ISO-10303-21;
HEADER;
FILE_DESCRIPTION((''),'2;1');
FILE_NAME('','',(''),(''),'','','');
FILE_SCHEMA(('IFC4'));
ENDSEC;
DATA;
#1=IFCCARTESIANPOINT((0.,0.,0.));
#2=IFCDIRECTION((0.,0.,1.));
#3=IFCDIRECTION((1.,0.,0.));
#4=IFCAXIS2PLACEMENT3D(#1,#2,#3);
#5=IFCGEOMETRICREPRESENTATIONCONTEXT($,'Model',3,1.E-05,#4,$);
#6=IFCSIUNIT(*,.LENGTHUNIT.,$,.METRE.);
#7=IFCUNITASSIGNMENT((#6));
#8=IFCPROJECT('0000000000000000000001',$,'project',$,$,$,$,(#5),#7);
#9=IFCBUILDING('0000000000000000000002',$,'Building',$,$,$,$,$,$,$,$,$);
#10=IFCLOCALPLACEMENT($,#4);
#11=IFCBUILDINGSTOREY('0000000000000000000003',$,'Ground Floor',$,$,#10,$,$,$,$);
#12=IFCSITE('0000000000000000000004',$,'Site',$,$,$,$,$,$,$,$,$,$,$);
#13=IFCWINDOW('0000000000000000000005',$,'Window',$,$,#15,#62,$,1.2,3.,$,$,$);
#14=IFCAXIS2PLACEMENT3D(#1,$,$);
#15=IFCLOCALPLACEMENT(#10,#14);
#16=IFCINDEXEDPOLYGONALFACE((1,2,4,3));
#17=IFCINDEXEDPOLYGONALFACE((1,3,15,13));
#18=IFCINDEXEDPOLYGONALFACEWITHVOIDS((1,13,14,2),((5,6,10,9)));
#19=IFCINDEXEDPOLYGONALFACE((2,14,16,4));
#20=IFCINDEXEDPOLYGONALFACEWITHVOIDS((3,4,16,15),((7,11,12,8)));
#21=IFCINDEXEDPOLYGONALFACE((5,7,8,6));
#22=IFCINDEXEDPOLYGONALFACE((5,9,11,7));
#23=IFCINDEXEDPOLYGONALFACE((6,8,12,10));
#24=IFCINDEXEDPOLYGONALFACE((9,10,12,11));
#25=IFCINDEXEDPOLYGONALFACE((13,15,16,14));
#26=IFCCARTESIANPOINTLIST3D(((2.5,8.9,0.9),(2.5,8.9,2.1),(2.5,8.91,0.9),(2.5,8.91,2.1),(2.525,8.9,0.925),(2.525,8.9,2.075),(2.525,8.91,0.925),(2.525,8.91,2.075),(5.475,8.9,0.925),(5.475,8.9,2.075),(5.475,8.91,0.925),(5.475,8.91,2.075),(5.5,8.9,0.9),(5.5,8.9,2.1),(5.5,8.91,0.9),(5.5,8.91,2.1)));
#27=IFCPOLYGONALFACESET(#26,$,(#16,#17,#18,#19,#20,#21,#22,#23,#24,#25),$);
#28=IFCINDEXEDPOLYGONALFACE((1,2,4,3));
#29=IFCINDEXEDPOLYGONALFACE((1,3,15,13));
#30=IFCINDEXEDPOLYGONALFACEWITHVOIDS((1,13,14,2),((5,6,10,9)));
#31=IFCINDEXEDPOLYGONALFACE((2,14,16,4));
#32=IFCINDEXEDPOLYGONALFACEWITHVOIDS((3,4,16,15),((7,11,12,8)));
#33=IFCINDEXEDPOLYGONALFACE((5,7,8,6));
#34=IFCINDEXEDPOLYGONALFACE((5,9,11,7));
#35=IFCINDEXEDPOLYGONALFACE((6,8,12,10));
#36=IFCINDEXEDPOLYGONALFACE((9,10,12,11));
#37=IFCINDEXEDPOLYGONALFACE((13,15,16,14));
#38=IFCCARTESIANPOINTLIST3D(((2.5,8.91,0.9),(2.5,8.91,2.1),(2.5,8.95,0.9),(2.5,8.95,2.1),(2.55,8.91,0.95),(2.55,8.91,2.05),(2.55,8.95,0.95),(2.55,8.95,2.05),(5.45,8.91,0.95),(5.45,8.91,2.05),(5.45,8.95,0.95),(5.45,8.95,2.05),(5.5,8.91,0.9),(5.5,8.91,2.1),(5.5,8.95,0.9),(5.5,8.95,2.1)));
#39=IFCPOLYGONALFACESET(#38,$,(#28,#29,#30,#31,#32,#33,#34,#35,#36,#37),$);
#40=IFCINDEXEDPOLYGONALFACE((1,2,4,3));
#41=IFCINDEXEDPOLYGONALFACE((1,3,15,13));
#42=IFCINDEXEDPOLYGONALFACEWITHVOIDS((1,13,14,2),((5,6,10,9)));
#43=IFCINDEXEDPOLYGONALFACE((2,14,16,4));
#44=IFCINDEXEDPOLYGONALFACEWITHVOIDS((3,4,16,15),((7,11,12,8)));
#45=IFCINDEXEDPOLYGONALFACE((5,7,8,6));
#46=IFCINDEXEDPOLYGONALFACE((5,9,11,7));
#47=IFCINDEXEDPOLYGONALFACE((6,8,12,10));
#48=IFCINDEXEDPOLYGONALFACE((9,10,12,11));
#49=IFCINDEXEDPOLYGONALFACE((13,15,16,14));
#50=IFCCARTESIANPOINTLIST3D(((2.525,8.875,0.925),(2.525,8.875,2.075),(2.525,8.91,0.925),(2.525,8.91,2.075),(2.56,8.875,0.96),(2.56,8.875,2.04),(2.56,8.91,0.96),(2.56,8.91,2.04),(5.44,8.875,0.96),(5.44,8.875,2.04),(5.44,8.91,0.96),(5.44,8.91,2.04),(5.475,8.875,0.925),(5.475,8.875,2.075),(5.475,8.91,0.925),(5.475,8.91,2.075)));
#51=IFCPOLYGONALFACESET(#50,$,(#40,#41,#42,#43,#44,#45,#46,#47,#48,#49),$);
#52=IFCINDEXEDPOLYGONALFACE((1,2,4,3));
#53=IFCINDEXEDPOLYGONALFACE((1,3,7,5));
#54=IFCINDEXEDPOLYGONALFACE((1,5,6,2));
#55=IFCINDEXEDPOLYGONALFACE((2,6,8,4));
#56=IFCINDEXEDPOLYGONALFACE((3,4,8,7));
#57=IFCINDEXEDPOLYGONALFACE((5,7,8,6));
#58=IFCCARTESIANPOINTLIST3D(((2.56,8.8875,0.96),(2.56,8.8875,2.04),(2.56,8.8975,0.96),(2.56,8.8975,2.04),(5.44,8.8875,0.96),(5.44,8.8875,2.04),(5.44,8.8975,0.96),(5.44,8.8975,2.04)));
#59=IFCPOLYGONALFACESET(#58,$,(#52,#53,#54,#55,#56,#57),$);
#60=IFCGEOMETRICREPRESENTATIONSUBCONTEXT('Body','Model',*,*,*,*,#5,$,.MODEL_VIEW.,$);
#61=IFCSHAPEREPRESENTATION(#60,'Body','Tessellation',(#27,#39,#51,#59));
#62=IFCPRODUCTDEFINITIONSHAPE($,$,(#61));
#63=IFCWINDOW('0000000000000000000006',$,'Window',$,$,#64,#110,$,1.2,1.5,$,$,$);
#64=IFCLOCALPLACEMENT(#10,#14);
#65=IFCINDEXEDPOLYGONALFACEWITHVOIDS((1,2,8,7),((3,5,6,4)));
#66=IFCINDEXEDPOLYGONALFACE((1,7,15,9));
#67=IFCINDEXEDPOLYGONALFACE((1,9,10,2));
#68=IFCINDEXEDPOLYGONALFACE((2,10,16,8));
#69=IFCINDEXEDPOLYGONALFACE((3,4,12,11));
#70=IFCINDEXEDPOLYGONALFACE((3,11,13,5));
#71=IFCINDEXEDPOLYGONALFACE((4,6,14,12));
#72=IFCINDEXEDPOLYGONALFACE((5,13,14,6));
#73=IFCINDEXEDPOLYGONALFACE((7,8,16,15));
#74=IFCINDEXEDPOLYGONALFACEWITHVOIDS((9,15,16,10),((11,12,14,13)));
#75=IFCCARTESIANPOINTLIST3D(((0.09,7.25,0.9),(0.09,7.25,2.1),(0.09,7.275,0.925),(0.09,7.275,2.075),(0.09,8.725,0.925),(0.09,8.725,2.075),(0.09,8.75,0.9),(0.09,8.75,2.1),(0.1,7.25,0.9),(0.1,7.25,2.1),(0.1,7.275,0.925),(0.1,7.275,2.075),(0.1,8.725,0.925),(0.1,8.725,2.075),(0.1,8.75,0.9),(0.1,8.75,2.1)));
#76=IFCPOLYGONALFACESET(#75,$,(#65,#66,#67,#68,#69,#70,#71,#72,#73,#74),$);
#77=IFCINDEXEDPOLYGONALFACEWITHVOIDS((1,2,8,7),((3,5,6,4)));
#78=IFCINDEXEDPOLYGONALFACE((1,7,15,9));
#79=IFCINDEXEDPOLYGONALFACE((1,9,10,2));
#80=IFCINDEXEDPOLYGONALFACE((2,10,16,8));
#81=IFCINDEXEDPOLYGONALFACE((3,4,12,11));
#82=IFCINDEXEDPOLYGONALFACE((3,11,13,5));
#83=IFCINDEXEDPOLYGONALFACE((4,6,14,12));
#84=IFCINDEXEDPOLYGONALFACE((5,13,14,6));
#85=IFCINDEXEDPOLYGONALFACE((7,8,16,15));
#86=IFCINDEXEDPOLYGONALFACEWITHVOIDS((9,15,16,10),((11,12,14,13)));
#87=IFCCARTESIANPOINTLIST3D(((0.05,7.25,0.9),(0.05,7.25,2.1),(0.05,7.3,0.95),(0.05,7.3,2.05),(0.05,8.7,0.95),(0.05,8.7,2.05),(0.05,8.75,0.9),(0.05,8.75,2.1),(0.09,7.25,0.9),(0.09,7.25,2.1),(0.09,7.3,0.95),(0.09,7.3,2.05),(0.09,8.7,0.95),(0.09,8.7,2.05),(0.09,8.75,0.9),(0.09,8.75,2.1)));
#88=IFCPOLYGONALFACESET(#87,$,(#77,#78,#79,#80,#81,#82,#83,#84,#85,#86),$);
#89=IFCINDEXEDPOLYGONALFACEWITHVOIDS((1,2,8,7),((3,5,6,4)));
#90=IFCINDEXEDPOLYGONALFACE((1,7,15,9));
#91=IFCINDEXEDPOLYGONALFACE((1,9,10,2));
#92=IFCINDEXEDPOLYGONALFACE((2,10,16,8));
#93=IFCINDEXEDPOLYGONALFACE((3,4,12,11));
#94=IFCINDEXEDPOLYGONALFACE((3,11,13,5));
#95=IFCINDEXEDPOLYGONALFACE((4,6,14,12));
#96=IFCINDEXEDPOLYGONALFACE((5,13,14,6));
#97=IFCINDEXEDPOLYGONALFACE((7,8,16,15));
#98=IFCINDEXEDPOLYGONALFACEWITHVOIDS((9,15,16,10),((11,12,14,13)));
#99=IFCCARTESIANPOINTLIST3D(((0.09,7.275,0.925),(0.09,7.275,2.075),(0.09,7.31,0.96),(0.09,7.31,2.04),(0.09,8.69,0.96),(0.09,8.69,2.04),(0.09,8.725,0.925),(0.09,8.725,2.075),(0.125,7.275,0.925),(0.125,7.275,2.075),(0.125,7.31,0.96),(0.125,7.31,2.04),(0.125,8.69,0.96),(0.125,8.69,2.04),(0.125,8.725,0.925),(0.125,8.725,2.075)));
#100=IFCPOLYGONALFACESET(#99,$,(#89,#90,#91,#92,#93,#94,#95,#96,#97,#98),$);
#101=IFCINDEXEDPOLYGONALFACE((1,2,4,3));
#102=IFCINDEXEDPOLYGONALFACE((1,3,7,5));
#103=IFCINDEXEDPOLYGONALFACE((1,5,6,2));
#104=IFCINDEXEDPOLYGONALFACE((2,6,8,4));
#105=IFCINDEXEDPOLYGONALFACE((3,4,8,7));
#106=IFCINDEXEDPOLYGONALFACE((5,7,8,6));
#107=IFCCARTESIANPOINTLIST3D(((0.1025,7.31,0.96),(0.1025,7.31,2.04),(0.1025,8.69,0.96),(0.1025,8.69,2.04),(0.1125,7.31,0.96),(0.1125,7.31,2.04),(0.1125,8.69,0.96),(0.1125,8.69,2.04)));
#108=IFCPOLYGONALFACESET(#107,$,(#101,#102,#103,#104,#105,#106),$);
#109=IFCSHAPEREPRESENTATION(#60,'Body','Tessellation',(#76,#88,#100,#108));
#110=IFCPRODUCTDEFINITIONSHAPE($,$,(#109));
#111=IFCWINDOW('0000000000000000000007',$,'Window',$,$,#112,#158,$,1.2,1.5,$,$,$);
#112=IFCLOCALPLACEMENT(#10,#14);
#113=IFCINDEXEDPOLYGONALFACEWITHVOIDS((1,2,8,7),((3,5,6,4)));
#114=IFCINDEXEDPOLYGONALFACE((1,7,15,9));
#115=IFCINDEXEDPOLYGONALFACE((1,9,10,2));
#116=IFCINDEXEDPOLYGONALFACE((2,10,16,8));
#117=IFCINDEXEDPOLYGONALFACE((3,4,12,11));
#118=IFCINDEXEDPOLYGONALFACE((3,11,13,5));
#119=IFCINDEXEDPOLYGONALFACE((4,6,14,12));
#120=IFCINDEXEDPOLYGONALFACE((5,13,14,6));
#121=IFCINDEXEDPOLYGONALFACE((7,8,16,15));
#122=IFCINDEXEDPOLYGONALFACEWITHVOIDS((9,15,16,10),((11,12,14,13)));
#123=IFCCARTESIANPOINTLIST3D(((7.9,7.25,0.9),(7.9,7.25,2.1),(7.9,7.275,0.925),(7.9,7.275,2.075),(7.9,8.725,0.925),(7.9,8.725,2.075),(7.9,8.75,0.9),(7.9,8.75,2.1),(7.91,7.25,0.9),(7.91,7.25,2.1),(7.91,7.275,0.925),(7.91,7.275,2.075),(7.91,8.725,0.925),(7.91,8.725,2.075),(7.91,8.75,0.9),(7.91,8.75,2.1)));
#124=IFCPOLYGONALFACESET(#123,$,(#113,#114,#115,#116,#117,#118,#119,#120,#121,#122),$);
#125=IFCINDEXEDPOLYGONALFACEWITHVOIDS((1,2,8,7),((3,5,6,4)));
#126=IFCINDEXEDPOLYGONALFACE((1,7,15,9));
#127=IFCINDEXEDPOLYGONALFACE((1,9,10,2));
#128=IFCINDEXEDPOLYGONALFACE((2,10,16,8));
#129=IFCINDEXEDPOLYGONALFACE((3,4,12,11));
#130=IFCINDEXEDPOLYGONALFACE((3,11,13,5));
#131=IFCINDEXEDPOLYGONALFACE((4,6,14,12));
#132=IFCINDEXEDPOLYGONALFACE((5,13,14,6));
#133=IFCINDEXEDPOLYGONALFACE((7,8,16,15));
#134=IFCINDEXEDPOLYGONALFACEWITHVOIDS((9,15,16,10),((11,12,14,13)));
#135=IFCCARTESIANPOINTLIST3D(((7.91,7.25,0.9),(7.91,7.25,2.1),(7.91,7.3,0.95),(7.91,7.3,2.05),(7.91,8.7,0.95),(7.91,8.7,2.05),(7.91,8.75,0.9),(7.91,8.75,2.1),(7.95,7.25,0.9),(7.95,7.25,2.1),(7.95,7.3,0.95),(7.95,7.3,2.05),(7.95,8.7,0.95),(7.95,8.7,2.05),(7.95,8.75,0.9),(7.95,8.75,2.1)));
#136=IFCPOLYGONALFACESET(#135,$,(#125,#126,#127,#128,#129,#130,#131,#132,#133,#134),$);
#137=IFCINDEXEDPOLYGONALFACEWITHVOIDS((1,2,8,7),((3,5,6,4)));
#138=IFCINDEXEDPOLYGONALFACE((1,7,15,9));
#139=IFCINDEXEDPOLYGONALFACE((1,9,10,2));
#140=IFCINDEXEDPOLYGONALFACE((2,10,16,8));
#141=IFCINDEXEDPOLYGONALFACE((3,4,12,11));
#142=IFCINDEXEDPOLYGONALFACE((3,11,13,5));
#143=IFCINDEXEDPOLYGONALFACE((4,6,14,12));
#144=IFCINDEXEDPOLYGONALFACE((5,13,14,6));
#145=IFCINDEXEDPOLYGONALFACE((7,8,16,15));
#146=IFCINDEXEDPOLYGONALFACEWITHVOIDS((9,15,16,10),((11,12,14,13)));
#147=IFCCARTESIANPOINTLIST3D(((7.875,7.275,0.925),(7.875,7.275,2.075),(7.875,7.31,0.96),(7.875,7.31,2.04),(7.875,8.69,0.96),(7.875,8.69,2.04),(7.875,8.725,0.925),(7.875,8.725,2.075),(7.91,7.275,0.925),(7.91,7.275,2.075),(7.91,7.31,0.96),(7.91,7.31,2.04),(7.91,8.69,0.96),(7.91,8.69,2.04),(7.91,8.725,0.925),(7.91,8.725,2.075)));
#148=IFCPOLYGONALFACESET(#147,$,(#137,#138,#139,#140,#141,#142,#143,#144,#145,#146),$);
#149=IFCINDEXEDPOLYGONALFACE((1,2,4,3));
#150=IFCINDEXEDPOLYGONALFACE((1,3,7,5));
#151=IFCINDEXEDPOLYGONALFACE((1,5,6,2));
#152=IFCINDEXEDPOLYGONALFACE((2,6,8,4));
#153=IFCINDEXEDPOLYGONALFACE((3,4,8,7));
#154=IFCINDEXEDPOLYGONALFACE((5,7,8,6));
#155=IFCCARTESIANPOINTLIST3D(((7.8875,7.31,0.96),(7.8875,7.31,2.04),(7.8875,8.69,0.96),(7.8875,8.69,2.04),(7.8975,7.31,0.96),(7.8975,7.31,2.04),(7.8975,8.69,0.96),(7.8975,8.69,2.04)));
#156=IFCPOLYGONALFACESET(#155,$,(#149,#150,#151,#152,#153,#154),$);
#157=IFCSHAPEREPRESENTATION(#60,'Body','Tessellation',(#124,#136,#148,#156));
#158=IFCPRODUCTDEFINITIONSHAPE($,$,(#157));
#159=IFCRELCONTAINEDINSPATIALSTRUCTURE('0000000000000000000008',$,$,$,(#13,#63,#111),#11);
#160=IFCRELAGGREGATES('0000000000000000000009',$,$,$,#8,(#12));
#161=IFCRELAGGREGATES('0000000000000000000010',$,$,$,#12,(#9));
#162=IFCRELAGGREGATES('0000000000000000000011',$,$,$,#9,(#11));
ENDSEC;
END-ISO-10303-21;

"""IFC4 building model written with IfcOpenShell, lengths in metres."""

from ifc_helpers import new_model, si_unit, frame, origin_with_axes, place, context, subcontext, project, spatial, line, indexed_curve, outline, extrude, element, save


model = new_model("IFC4")

# Units and contexts
model_context = context("Model", 3, precision=1e-05, world=origin_with_axes())
body_context = subcontext(model_context, "Body", "Model", "MODEL_VIEW")
ifc_project = project(units=[si_unit("LENGTHUNIT", "METRE")], contexts=[model_context])

# Site, building, storey
site = spatial("IfcSite", under=ifc_project, Name="Site")
building = spatial("IfcBuilding", under=site, Name="Building")
storey_placement = place(None, origin_with_axes())
storey = spatial("IfcBuildingStorey", under=building, at=storey_placement, Name="Ground Floor")

# Windows
window_placement = place(storey_placement, frame((5.5, 9.0, 0.9), z_axis=(0.0, 0.0, 1.0), x_axis=(-1.0, 0.0, 0.0)))
element("IfcWindow", 1, at=window_placement, inside=storey, Name="Window", OverallHeight=1.2, OverallWidth=3.0, context=body_context, shape_type="SweptSolid", body=[
    extrude(outline(indexed_curve([(0.0, 0.0), (3.0, 0.0), (3.0, 1.2), (0.0, 1.2)], segments=[line(1, 2, 3, 4, 1)]), holes=[indexed_curve([(0.025, 0.025), (2.975, 0.025), (2.975, 1.175), (0.025, 1.175)], segments=[line(1, 2, 3, 4, 1)])]), frame((0.0, 0.09, 0.0), z_axis=(0.0, -1.0, 0.0), x_axis=(1.0, 0.0, 0.0)), (0.0, 0.0, -1.0), 0.01),
    extrude(outline(indexed_curve([(0.0, 0.0), (3.0, 0.0), (3.0, 1.2), (0.0, 1.2)], segments=[line(1, 2, 3, 4, 1)]), holes=[indexed_curve([(0.05, 0.05), (2.95, 0.05), (2.95, 1.15), (0.05, 1.15)], segments=[line(1, 2, 3, 4, 1)])]), frame((0.0, 0.05, 0.0), z_axis=(0.0, -1.0, 0.0), x_axis=(1.0, 0.0, 0.0)), (0.0, 0.0, -1.0), 0.04),
    extrude(outline(indexed_curve([(0.0, 0.0), (2.95, 0.0), (2.95, 1.15), (0.0, 1.15)], segments=[line(1, 2, 3, 4, 1)]), holes=[indexed_curve([(0.035, 0.035), (2.915, 0.035), (2.915, 1.115), (0.035, 1.115)], segments=[line(1, 2, 3, 4, 1)])]), frame((0.025, 0.09, 0.025), z_axis=(0.0, -1.0, 0.0), x_axis=(1.0, 0.0, 0.0)), (0.0, 0.0, -1.0), 0.035),
    extrude(outline(indexed_curve([(0.035, 0.035), (2.915, 0.035), (2.915, 1.115), (0.035, 1.115)], segments=[line(1, 2, 3, 4, 1)])), frame((0.025, 0.1025, 0.025), z_axis=(0.0, -1.0, 0.0), x_axis=(1.0, 0.0, 0.0)), (0.0, 0.0, -1.0), 0.01),
])
for number, where, z_axis, x_axis, name in (
    (2, (0.0, 8.75, 0.9), (0.0, 0.0, 1.0), (0.0, -1.0, 0.0), "Window"),
    (3, (8.0, 7.25, 0.9), (0.0, 0.0, 1.0), (0.0, 1.0, 0.0), "Window"),
):
    element("IfcWindow", number, at=place(storey_placement, frame(where, z_axis=z_axis, x_axis=x_axis)), inside=storey, Name=name, OverallHeight=1.2, OverallWidth=1.5, context=body_context, shape_type="SweptSolid", body=[
        extrude(outline(indexed_curve([(0.0, 0.0), (1.5, 0.0), (1.5, 1.2), (0.0, 1.2)], segments=[line(1, 2, 3, 4, 1)]), holes=[indexed_curve([(0.025, 0.025), (1.475, 0.025), (1.475, 1.175), (0.025, 1.175)], segments=[line(1, 2, 3, 4, 1)])]), frame((0.0, 0.09, 0.0), z_axis=(0.0, -1.0, 0.0), x_axis=(1.0, 0.0, 0.0)), (0.0, 0.0, -1.0), 0.01),
        extrude(outline(indexed_curve([(0.0, 0.0), (1.5, 0.0), (1.5, 1.2), (0.0, 1.2)], segments=[line(1, 2, 3, 4, 1)]), holes=[indexed_curve([(0.05, 0.05), (1.45, 0.05), (1.45, 1.15), (0.05, 1.15)], segments=[line(1, 2, 3, 4, 1)])]), frame((0.0, 0.05, 0.0), z_axis=(0.0, -1.0, 0.0), x_axis=(1.0, 0.0, 0.0)), (0.0, 0.0, -1.0), 0.04),
        extrude(outline(indexed_curve([(0.0, 0.0), (1.45, 0.0), (1.45, 1.15), (0.0, 1.15)], segments=[line(1, 2, 3, 4, 1)]), holes=[indexed_curve([(0.035, 0.035), (1.415, 0.035), (1.415, 1.115), (0.035, 1.115)], segments=[line(1, 2, 3, 4, 1)])]), frame((0.025, 0.09, 0.025), z_axis=(0.0, -1.0, 0.0), x_axis=(1.0, 0.0, 0.0)), (0.0, 0.0, -1.0), 0.035),
        extrude(outline(indexed_curve([(0.035, 0.035), (1.415, 0.035), (1.415, 1.115), (0.035, 1.115)], segments=[line(1, 2, 3, 4, 1)])), frame((0.025, 0.1025, 0.025), z_axis=(0.0, -1.0, 0.0), x_axis=(1.0, 0.0, 0.0)), (0.0, 0.0, -1.0), 0.01),
    ])

save(model, "model.ifc")
